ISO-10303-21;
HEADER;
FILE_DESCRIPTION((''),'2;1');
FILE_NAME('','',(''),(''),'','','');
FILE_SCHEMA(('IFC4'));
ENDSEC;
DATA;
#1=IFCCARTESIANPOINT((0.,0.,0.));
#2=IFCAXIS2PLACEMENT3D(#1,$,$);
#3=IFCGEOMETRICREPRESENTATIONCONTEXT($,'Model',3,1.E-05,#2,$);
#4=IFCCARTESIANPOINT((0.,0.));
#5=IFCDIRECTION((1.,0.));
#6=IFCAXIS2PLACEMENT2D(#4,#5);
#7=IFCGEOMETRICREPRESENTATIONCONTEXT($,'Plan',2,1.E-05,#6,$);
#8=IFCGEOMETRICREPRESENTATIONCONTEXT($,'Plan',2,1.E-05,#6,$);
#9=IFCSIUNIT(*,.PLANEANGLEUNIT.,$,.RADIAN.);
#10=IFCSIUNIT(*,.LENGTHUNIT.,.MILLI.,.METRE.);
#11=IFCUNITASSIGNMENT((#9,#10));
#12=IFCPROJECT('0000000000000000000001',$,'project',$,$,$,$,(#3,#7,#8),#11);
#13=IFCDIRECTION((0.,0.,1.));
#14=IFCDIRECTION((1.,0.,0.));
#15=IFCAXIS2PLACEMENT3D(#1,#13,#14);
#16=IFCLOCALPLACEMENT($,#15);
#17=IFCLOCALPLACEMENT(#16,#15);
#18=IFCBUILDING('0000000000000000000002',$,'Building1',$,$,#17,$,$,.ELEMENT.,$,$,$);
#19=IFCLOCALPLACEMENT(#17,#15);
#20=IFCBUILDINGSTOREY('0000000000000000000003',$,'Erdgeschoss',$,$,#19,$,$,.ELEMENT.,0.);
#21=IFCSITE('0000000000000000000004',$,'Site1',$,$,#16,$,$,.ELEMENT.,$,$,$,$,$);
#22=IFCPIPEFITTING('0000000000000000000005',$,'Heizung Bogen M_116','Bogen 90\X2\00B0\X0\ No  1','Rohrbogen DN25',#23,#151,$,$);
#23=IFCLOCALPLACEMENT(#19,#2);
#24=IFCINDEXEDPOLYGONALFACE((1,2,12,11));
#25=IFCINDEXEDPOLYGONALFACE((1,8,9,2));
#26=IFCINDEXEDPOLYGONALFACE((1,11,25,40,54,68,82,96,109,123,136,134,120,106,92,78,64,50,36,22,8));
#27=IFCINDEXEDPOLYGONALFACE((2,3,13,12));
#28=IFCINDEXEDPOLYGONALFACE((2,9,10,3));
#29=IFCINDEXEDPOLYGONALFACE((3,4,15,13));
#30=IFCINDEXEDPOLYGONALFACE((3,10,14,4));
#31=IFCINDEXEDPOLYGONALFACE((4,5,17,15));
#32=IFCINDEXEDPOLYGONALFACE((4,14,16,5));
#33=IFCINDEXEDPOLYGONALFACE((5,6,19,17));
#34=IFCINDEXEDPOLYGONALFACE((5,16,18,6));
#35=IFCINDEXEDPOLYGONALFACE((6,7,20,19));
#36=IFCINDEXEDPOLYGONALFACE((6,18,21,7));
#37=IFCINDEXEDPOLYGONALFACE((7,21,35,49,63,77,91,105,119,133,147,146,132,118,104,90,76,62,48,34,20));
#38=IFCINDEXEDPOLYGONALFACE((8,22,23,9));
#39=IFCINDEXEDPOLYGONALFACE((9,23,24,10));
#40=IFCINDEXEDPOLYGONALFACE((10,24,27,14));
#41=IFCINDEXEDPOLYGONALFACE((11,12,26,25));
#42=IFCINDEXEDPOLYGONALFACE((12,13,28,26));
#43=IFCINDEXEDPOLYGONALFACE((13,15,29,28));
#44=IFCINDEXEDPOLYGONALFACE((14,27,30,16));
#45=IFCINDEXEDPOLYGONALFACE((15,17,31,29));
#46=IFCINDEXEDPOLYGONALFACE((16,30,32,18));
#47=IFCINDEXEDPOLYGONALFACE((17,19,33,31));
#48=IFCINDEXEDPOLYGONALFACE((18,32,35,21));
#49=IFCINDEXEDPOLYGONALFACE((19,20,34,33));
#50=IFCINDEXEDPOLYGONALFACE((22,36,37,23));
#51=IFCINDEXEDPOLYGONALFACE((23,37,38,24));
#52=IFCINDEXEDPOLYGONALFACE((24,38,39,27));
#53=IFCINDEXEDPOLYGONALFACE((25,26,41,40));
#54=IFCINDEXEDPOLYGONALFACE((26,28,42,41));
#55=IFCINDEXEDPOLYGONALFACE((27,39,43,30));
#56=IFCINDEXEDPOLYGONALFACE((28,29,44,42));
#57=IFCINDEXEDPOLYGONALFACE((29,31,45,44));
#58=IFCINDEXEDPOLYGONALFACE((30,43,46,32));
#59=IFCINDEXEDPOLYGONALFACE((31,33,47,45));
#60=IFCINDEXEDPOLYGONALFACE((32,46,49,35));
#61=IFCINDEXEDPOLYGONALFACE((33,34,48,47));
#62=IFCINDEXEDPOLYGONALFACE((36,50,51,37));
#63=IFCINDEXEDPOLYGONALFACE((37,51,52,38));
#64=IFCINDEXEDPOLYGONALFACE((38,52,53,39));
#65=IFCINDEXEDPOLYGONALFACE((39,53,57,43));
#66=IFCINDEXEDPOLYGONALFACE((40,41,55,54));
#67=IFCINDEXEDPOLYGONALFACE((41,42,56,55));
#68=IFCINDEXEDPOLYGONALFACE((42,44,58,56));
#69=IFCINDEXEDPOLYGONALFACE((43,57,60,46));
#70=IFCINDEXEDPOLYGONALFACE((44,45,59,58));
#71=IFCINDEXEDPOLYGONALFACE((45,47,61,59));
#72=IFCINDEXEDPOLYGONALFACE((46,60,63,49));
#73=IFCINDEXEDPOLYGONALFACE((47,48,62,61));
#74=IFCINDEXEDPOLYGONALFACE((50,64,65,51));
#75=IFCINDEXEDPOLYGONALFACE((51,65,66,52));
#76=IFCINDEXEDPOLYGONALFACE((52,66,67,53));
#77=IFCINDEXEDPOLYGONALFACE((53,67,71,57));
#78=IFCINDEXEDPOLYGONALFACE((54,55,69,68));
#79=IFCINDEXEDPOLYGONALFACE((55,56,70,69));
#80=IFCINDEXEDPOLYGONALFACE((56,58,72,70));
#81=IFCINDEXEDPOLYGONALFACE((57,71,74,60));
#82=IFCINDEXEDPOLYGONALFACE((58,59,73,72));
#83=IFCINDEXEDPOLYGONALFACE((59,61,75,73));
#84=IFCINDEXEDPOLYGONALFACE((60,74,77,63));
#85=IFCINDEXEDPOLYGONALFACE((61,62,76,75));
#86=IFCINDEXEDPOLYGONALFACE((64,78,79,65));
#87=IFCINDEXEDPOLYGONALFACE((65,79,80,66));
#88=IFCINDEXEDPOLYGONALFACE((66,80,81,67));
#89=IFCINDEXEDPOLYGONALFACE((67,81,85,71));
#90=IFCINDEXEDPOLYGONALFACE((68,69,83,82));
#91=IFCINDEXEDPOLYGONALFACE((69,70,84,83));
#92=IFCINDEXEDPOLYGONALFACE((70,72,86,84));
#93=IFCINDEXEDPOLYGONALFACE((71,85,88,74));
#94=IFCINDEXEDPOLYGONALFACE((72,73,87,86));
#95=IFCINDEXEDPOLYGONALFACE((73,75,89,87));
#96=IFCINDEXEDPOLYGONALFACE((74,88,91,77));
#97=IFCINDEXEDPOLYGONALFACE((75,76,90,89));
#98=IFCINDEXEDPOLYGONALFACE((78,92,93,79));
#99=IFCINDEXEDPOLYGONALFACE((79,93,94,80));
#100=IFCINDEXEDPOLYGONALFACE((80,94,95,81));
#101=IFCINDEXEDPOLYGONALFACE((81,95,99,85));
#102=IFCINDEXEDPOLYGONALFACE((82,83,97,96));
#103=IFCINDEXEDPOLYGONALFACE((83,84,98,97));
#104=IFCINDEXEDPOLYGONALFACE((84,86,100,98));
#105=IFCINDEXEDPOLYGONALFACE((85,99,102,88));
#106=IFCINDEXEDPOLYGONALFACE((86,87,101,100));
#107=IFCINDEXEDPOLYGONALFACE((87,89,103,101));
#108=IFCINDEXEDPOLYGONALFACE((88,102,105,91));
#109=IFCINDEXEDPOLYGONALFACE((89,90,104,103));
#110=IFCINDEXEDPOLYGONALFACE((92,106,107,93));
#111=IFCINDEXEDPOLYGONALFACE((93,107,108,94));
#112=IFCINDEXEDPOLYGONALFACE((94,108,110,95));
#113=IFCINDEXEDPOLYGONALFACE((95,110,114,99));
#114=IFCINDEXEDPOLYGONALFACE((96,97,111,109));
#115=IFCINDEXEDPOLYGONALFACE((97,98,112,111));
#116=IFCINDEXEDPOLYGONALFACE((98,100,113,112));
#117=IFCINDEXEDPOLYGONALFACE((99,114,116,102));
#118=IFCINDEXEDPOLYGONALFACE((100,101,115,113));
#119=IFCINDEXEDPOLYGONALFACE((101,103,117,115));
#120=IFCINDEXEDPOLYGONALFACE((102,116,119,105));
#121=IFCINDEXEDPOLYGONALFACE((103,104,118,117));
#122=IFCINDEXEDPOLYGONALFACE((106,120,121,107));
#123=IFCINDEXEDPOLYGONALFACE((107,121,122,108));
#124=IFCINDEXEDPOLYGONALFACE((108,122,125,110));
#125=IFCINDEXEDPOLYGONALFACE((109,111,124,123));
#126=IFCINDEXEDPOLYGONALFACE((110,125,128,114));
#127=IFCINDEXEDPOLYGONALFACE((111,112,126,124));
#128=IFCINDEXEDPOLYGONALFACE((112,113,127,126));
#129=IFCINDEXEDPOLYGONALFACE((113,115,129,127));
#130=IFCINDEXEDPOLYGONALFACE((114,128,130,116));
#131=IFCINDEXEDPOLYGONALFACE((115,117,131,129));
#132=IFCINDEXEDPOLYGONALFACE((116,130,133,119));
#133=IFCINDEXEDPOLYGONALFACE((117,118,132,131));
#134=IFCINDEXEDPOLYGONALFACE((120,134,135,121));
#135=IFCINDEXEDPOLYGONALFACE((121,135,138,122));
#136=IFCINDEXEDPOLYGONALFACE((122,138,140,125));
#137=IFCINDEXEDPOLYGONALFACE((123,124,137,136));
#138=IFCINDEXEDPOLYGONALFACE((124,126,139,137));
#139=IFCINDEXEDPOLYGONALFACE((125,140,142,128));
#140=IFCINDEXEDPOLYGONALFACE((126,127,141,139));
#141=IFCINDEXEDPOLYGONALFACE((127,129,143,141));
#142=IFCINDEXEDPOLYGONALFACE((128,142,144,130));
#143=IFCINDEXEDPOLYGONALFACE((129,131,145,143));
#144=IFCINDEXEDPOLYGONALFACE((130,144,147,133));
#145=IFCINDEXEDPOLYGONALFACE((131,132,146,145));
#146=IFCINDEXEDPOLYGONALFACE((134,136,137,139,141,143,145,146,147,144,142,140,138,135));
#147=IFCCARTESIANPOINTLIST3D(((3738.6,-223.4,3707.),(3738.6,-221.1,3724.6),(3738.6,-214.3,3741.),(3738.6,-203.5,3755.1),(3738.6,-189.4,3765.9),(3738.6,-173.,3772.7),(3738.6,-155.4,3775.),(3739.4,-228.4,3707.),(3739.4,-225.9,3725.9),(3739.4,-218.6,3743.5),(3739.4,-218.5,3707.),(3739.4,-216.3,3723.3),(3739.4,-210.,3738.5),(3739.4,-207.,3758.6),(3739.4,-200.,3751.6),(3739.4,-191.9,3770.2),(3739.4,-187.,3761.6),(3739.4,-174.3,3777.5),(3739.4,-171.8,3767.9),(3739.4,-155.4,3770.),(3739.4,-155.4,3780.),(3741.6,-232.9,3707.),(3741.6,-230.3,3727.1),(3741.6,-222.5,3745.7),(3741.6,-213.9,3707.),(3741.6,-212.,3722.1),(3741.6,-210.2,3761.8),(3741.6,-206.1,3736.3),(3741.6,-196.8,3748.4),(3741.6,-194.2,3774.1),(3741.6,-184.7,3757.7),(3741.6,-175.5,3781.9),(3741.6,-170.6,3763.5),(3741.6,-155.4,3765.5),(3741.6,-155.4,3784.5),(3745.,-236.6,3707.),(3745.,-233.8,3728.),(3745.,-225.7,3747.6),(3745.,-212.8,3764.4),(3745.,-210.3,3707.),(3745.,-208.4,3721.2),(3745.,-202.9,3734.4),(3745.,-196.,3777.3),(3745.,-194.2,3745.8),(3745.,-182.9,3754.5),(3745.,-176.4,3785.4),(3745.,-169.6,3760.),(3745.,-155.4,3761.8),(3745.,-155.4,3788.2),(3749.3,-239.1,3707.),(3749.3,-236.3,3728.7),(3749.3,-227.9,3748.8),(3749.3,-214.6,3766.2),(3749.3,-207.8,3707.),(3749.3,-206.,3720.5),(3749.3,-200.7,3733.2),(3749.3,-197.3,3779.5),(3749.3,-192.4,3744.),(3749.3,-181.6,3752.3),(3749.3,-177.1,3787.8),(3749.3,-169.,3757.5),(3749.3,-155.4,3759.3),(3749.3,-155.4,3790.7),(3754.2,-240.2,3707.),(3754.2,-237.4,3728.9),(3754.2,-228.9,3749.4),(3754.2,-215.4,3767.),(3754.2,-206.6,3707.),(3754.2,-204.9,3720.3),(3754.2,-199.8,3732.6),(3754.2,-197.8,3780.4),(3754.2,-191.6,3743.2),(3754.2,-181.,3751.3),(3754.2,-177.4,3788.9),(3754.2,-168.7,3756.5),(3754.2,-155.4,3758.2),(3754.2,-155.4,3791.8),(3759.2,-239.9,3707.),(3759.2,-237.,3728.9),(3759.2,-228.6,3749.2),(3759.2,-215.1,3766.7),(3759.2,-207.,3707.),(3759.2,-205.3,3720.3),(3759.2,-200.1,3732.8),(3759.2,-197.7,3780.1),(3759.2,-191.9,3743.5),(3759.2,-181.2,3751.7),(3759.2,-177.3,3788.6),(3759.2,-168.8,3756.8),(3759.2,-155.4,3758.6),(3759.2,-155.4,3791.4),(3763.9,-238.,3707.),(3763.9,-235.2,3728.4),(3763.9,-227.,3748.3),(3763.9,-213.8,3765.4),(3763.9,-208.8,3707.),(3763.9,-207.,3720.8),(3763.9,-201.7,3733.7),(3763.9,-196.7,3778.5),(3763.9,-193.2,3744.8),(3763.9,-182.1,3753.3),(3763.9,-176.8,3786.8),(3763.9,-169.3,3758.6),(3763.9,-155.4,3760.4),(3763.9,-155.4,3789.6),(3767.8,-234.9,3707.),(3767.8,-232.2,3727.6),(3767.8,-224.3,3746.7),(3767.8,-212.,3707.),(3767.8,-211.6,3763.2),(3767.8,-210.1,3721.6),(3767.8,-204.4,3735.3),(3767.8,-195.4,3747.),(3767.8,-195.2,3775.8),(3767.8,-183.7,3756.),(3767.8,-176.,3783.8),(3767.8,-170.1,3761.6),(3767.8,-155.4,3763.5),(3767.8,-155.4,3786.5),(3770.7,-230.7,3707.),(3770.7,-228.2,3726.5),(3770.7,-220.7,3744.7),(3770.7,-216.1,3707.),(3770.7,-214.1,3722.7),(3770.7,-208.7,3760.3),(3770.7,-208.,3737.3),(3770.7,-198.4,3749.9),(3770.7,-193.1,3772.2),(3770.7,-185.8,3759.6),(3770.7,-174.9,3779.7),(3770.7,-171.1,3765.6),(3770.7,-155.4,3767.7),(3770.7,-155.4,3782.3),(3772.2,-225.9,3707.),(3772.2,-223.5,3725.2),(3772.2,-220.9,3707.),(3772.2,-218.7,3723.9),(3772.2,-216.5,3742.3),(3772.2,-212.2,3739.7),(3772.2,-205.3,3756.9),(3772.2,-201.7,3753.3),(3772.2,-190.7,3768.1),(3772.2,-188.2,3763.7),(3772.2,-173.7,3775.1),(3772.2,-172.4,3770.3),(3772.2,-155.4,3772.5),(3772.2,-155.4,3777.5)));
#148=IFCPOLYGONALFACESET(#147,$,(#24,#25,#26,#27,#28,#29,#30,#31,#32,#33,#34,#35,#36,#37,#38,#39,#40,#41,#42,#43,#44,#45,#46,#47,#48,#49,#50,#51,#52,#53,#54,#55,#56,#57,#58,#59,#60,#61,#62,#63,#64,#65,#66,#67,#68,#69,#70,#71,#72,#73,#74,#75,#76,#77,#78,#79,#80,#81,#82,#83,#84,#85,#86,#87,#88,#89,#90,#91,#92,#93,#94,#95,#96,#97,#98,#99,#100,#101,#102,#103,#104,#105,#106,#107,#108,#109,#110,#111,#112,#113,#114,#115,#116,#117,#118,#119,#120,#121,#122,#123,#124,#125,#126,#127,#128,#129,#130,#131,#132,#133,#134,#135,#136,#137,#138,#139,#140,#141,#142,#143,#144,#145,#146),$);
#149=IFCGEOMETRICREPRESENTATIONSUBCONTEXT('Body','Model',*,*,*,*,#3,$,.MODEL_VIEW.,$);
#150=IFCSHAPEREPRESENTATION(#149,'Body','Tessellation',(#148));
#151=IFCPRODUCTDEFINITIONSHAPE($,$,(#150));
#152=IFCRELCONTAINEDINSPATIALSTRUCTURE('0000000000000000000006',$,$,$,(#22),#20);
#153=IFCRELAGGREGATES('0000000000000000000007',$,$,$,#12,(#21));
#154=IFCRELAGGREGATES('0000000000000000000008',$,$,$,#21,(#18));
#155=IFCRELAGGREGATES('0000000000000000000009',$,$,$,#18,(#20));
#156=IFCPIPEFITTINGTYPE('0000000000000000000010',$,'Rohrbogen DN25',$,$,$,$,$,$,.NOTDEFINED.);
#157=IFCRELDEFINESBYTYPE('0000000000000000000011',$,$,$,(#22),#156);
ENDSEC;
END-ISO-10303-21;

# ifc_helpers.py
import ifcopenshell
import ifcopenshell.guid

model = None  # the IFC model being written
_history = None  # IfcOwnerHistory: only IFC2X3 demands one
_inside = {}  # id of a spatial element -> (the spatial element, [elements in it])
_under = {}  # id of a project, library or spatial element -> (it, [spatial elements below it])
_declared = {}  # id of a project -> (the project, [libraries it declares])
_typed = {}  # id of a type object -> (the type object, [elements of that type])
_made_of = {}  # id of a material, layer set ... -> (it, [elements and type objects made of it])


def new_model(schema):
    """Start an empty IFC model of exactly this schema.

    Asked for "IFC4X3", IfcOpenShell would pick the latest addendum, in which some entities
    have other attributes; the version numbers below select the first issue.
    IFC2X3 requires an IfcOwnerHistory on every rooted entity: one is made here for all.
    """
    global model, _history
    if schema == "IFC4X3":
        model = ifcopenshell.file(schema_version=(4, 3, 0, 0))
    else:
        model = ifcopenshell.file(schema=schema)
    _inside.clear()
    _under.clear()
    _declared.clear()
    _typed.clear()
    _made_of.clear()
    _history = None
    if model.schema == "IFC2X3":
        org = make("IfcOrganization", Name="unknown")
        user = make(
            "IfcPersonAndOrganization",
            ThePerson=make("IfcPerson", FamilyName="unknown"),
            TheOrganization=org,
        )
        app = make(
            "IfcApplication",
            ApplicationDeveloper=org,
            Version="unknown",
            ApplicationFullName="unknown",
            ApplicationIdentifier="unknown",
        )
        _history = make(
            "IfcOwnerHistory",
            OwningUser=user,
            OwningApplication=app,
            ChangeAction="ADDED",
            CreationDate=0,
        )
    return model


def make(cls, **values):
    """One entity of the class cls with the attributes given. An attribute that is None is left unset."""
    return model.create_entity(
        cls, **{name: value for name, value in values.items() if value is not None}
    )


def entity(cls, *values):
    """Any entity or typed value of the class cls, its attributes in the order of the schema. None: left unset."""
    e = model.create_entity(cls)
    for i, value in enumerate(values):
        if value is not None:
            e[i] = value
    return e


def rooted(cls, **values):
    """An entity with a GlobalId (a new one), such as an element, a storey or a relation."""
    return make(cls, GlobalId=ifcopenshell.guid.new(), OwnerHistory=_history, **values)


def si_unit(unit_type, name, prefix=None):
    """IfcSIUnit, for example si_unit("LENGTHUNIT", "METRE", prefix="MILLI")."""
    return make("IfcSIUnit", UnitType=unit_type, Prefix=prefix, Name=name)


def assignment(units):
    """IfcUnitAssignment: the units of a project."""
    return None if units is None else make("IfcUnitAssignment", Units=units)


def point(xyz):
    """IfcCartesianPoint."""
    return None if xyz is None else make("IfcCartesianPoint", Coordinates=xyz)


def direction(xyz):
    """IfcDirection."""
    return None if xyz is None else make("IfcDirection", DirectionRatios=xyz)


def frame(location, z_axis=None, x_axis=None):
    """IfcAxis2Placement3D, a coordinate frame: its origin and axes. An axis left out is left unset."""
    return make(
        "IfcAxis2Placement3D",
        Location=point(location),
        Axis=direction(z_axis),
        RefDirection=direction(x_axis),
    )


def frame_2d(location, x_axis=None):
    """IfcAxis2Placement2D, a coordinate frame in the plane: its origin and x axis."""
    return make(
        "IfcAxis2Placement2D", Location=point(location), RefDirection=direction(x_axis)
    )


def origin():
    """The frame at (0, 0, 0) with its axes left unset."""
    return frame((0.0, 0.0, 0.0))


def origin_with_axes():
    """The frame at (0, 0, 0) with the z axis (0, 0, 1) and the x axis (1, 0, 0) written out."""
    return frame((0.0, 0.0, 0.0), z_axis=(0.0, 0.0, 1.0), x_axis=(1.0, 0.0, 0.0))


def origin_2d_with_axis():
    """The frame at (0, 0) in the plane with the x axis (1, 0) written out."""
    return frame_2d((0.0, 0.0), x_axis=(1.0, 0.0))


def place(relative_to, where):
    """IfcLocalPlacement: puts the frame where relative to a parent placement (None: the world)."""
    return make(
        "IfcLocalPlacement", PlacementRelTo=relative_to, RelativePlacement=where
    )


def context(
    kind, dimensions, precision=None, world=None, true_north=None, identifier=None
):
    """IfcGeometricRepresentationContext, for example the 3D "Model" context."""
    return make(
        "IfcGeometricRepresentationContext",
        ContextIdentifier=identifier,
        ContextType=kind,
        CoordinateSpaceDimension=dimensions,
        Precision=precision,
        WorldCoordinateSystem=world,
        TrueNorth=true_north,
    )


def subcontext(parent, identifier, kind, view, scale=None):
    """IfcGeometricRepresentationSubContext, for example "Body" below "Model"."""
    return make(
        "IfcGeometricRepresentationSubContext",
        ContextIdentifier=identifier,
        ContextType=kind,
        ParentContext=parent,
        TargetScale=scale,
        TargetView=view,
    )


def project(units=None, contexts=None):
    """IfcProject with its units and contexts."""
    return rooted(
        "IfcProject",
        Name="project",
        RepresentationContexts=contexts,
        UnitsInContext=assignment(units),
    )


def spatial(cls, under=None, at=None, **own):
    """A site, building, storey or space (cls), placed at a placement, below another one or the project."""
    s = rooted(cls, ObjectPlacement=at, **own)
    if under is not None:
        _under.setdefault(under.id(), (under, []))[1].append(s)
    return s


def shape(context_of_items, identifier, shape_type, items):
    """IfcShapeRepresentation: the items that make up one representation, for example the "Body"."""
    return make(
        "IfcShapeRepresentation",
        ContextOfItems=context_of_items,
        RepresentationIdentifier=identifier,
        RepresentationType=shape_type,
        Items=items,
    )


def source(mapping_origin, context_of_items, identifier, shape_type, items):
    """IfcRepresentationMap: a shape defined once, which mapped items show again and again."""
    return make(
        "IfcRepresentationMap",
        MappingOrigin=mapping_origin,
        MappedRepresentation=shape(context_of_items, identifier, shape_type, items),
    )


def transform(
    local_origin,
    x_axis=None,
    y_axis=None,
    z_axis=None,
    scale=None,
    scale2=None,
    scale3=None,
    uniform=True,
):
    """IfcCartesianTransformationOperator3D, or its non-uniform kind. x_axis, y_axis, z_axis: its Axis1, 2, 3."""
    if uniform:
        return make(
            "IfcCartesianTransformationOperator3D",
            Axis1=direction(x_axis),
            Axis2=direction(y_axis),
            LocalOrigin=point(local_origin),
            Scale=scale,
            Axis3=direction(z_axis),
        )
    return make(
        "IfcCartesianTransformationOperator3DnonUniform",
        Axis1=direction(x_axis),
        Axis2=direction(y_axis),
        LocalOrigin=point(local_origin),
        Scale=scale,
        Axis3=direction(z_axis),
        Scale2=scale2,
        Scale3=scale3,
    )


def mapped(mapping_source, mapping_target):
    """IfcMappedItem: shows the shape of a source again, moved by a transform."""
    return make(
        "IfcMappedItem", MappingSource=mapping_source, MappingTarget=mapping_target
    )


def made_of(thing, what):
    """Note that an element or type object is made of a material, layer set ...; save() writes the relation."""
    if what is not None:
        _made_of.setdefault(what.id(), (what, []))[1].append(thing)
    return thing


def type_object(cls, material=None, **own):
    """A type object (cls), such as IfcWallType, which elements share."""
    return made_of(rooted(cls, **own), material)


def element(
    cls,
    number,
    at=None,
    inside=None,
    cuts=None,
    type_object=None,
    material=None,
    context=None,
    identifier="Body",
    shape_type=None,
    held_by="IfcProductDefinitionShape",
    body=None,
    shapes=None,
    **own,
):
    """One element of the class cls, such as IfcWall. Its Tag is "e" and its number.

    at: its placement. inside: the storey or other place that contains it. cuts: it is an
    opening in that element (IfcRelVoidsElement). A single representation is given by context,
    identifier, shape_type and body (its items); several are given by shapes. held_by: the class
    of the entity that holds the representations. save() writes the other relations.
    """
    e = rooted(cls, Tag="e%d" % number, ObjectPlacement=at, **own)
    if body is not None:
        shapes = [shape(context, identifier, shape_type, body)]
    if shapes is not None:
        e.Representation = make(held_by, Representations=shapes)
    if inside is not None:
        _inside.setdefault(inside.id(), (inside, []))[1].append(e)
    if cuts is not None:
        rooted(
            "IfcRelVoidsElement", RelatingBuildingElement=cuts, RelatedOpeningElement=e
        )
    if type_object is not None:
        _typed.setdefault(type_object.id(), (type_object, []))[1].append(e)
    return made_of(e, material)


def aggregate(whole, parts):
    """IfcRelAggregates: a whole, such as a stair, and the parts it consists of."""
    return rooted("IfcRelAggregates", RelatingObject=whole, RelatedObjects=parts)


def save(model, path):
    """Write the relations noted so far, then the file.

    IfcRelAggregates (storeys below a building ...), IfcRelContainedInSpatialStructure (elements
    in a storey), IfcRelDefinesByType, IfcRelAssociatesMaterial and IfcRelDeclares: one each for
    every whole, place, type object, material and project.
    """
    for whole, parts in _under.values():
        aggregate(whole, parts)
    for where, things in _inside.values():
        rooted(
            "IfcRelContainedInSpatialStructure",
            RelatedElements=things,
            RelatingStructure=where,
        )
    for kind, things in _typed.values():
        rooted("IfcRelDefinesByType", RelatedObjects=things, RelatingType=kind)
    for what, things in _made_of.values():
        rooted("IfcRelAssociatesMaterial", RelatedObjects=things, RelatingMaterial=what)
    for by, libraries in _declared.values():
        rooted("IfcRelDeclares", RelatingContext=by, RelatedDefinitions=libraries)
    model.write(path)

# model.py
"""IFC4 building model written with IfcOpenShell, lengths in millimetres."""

from ifc_helpers import new_model, entity, si_unit, frame, origin, origin_with_axes, origin_2d_with_axis, place, context, subcontext, project, spatial, source, transform, mapped, type_object, element, save


model = new_model("IFC4")

# Units and contexts
model_context = context("Model", 3, precision=1e-05, world=origin())
plan_context_1 = context("Plan", 2, precision=1e-05, world=origin_2d_with_axis())
plan_context_2 = context("Plan", 2, precision=1e-05, world=origin_2d_with_axis())
body_context = subcontext(model_context, "Body", "Model", "MODEL_VIEW")
ifc_project = project(units=[si_unit("PLANEANGLEUNIT", "RADIAN"), si_unit("LENGTHUNIT", "METRE", prefix="MILLI")], contexts=[model_context, plan_context_1, plan_context_2])

# Site, building, storey
site_placement = place(None, origin_with_axes())
site = spatial("IfcSite", under=ifc_project, at=site_placement, Name="Site1", CompositionType="ELEMENT")
building_placement = place(site_placement, origin_with_axes())
building = spatial("IfcBuilding", under=site, at=building_placement, Name="Building1", CompositionType="ELEMENT")
storey_placement = place(building_placement, origin_with_axes())
storey = spatial("IfcBuildingStorey", under=building, at=storey_placement, Name="Erdgeschoss", CompositionType="ELEMENT", Elevation=0.0)

# Pipe fitting
pipe_fitting_type_1 = type_object("IfcPipeFittingType", Name="Rohrbogen DN25", PredefinedType="NOTDEFINED")
shared_shape_1 = source(origin_with_axes(), body_context, "Body", "SolidModel", [
    entity("IfcRevolvedAreaSolid", entity("IfcCircleProfileDef", "AREA", None, entity("IfcAxis2Placement2D", entity("IfcCartesianPoint", [0.0, 0.0]), entity("IfcDirection", [1.0, 0.0])), 16.9), entity("IfcAxis2Placement3D", entity("IfcCartesianPoint", [-42.4, 0.0, 25.6]), entity("IfcDirection", [1.0, 0.0, 0.0]), entity("IfcDirection", [0.0, -1.0, 0.0])), entity("IfcAxis1Placement", entity("IfcCartesianPoint", [0.0, 68.0, 0.0]), entity("IfcDirection", [-1.0, 0.0, 0.0])), 1.570796),
])
pipe_fitting_1_placement = place(storey_placement, frame((3755.5, -197.9, 3749.4), z_axis=(0.0, 0.0, 1.0), x_axis=(1.0, 0.0, 0.0)))
element("IfcPipeFitting", 1, at=pipe_fitting_1_placement, inside=storey, type_object=pipe_fitting_type_1, Name="Heizung Bogen M_116", Description="Bogen 90° No  1", ObjectType="Rohrbogen DN25", context=body_context, shape_type="MappedRepresentation", body=[
    mapped(shared_shape_1, transform((0.0, 0.0, 0.0), x_axis=(0.0, -1.0, 0.0), y_axis=(1.0, 0.0, 0.0), z_axis=(0.0, 0.0, 1.0), scale=1.0)),
])

save(model, "model.ifc")
